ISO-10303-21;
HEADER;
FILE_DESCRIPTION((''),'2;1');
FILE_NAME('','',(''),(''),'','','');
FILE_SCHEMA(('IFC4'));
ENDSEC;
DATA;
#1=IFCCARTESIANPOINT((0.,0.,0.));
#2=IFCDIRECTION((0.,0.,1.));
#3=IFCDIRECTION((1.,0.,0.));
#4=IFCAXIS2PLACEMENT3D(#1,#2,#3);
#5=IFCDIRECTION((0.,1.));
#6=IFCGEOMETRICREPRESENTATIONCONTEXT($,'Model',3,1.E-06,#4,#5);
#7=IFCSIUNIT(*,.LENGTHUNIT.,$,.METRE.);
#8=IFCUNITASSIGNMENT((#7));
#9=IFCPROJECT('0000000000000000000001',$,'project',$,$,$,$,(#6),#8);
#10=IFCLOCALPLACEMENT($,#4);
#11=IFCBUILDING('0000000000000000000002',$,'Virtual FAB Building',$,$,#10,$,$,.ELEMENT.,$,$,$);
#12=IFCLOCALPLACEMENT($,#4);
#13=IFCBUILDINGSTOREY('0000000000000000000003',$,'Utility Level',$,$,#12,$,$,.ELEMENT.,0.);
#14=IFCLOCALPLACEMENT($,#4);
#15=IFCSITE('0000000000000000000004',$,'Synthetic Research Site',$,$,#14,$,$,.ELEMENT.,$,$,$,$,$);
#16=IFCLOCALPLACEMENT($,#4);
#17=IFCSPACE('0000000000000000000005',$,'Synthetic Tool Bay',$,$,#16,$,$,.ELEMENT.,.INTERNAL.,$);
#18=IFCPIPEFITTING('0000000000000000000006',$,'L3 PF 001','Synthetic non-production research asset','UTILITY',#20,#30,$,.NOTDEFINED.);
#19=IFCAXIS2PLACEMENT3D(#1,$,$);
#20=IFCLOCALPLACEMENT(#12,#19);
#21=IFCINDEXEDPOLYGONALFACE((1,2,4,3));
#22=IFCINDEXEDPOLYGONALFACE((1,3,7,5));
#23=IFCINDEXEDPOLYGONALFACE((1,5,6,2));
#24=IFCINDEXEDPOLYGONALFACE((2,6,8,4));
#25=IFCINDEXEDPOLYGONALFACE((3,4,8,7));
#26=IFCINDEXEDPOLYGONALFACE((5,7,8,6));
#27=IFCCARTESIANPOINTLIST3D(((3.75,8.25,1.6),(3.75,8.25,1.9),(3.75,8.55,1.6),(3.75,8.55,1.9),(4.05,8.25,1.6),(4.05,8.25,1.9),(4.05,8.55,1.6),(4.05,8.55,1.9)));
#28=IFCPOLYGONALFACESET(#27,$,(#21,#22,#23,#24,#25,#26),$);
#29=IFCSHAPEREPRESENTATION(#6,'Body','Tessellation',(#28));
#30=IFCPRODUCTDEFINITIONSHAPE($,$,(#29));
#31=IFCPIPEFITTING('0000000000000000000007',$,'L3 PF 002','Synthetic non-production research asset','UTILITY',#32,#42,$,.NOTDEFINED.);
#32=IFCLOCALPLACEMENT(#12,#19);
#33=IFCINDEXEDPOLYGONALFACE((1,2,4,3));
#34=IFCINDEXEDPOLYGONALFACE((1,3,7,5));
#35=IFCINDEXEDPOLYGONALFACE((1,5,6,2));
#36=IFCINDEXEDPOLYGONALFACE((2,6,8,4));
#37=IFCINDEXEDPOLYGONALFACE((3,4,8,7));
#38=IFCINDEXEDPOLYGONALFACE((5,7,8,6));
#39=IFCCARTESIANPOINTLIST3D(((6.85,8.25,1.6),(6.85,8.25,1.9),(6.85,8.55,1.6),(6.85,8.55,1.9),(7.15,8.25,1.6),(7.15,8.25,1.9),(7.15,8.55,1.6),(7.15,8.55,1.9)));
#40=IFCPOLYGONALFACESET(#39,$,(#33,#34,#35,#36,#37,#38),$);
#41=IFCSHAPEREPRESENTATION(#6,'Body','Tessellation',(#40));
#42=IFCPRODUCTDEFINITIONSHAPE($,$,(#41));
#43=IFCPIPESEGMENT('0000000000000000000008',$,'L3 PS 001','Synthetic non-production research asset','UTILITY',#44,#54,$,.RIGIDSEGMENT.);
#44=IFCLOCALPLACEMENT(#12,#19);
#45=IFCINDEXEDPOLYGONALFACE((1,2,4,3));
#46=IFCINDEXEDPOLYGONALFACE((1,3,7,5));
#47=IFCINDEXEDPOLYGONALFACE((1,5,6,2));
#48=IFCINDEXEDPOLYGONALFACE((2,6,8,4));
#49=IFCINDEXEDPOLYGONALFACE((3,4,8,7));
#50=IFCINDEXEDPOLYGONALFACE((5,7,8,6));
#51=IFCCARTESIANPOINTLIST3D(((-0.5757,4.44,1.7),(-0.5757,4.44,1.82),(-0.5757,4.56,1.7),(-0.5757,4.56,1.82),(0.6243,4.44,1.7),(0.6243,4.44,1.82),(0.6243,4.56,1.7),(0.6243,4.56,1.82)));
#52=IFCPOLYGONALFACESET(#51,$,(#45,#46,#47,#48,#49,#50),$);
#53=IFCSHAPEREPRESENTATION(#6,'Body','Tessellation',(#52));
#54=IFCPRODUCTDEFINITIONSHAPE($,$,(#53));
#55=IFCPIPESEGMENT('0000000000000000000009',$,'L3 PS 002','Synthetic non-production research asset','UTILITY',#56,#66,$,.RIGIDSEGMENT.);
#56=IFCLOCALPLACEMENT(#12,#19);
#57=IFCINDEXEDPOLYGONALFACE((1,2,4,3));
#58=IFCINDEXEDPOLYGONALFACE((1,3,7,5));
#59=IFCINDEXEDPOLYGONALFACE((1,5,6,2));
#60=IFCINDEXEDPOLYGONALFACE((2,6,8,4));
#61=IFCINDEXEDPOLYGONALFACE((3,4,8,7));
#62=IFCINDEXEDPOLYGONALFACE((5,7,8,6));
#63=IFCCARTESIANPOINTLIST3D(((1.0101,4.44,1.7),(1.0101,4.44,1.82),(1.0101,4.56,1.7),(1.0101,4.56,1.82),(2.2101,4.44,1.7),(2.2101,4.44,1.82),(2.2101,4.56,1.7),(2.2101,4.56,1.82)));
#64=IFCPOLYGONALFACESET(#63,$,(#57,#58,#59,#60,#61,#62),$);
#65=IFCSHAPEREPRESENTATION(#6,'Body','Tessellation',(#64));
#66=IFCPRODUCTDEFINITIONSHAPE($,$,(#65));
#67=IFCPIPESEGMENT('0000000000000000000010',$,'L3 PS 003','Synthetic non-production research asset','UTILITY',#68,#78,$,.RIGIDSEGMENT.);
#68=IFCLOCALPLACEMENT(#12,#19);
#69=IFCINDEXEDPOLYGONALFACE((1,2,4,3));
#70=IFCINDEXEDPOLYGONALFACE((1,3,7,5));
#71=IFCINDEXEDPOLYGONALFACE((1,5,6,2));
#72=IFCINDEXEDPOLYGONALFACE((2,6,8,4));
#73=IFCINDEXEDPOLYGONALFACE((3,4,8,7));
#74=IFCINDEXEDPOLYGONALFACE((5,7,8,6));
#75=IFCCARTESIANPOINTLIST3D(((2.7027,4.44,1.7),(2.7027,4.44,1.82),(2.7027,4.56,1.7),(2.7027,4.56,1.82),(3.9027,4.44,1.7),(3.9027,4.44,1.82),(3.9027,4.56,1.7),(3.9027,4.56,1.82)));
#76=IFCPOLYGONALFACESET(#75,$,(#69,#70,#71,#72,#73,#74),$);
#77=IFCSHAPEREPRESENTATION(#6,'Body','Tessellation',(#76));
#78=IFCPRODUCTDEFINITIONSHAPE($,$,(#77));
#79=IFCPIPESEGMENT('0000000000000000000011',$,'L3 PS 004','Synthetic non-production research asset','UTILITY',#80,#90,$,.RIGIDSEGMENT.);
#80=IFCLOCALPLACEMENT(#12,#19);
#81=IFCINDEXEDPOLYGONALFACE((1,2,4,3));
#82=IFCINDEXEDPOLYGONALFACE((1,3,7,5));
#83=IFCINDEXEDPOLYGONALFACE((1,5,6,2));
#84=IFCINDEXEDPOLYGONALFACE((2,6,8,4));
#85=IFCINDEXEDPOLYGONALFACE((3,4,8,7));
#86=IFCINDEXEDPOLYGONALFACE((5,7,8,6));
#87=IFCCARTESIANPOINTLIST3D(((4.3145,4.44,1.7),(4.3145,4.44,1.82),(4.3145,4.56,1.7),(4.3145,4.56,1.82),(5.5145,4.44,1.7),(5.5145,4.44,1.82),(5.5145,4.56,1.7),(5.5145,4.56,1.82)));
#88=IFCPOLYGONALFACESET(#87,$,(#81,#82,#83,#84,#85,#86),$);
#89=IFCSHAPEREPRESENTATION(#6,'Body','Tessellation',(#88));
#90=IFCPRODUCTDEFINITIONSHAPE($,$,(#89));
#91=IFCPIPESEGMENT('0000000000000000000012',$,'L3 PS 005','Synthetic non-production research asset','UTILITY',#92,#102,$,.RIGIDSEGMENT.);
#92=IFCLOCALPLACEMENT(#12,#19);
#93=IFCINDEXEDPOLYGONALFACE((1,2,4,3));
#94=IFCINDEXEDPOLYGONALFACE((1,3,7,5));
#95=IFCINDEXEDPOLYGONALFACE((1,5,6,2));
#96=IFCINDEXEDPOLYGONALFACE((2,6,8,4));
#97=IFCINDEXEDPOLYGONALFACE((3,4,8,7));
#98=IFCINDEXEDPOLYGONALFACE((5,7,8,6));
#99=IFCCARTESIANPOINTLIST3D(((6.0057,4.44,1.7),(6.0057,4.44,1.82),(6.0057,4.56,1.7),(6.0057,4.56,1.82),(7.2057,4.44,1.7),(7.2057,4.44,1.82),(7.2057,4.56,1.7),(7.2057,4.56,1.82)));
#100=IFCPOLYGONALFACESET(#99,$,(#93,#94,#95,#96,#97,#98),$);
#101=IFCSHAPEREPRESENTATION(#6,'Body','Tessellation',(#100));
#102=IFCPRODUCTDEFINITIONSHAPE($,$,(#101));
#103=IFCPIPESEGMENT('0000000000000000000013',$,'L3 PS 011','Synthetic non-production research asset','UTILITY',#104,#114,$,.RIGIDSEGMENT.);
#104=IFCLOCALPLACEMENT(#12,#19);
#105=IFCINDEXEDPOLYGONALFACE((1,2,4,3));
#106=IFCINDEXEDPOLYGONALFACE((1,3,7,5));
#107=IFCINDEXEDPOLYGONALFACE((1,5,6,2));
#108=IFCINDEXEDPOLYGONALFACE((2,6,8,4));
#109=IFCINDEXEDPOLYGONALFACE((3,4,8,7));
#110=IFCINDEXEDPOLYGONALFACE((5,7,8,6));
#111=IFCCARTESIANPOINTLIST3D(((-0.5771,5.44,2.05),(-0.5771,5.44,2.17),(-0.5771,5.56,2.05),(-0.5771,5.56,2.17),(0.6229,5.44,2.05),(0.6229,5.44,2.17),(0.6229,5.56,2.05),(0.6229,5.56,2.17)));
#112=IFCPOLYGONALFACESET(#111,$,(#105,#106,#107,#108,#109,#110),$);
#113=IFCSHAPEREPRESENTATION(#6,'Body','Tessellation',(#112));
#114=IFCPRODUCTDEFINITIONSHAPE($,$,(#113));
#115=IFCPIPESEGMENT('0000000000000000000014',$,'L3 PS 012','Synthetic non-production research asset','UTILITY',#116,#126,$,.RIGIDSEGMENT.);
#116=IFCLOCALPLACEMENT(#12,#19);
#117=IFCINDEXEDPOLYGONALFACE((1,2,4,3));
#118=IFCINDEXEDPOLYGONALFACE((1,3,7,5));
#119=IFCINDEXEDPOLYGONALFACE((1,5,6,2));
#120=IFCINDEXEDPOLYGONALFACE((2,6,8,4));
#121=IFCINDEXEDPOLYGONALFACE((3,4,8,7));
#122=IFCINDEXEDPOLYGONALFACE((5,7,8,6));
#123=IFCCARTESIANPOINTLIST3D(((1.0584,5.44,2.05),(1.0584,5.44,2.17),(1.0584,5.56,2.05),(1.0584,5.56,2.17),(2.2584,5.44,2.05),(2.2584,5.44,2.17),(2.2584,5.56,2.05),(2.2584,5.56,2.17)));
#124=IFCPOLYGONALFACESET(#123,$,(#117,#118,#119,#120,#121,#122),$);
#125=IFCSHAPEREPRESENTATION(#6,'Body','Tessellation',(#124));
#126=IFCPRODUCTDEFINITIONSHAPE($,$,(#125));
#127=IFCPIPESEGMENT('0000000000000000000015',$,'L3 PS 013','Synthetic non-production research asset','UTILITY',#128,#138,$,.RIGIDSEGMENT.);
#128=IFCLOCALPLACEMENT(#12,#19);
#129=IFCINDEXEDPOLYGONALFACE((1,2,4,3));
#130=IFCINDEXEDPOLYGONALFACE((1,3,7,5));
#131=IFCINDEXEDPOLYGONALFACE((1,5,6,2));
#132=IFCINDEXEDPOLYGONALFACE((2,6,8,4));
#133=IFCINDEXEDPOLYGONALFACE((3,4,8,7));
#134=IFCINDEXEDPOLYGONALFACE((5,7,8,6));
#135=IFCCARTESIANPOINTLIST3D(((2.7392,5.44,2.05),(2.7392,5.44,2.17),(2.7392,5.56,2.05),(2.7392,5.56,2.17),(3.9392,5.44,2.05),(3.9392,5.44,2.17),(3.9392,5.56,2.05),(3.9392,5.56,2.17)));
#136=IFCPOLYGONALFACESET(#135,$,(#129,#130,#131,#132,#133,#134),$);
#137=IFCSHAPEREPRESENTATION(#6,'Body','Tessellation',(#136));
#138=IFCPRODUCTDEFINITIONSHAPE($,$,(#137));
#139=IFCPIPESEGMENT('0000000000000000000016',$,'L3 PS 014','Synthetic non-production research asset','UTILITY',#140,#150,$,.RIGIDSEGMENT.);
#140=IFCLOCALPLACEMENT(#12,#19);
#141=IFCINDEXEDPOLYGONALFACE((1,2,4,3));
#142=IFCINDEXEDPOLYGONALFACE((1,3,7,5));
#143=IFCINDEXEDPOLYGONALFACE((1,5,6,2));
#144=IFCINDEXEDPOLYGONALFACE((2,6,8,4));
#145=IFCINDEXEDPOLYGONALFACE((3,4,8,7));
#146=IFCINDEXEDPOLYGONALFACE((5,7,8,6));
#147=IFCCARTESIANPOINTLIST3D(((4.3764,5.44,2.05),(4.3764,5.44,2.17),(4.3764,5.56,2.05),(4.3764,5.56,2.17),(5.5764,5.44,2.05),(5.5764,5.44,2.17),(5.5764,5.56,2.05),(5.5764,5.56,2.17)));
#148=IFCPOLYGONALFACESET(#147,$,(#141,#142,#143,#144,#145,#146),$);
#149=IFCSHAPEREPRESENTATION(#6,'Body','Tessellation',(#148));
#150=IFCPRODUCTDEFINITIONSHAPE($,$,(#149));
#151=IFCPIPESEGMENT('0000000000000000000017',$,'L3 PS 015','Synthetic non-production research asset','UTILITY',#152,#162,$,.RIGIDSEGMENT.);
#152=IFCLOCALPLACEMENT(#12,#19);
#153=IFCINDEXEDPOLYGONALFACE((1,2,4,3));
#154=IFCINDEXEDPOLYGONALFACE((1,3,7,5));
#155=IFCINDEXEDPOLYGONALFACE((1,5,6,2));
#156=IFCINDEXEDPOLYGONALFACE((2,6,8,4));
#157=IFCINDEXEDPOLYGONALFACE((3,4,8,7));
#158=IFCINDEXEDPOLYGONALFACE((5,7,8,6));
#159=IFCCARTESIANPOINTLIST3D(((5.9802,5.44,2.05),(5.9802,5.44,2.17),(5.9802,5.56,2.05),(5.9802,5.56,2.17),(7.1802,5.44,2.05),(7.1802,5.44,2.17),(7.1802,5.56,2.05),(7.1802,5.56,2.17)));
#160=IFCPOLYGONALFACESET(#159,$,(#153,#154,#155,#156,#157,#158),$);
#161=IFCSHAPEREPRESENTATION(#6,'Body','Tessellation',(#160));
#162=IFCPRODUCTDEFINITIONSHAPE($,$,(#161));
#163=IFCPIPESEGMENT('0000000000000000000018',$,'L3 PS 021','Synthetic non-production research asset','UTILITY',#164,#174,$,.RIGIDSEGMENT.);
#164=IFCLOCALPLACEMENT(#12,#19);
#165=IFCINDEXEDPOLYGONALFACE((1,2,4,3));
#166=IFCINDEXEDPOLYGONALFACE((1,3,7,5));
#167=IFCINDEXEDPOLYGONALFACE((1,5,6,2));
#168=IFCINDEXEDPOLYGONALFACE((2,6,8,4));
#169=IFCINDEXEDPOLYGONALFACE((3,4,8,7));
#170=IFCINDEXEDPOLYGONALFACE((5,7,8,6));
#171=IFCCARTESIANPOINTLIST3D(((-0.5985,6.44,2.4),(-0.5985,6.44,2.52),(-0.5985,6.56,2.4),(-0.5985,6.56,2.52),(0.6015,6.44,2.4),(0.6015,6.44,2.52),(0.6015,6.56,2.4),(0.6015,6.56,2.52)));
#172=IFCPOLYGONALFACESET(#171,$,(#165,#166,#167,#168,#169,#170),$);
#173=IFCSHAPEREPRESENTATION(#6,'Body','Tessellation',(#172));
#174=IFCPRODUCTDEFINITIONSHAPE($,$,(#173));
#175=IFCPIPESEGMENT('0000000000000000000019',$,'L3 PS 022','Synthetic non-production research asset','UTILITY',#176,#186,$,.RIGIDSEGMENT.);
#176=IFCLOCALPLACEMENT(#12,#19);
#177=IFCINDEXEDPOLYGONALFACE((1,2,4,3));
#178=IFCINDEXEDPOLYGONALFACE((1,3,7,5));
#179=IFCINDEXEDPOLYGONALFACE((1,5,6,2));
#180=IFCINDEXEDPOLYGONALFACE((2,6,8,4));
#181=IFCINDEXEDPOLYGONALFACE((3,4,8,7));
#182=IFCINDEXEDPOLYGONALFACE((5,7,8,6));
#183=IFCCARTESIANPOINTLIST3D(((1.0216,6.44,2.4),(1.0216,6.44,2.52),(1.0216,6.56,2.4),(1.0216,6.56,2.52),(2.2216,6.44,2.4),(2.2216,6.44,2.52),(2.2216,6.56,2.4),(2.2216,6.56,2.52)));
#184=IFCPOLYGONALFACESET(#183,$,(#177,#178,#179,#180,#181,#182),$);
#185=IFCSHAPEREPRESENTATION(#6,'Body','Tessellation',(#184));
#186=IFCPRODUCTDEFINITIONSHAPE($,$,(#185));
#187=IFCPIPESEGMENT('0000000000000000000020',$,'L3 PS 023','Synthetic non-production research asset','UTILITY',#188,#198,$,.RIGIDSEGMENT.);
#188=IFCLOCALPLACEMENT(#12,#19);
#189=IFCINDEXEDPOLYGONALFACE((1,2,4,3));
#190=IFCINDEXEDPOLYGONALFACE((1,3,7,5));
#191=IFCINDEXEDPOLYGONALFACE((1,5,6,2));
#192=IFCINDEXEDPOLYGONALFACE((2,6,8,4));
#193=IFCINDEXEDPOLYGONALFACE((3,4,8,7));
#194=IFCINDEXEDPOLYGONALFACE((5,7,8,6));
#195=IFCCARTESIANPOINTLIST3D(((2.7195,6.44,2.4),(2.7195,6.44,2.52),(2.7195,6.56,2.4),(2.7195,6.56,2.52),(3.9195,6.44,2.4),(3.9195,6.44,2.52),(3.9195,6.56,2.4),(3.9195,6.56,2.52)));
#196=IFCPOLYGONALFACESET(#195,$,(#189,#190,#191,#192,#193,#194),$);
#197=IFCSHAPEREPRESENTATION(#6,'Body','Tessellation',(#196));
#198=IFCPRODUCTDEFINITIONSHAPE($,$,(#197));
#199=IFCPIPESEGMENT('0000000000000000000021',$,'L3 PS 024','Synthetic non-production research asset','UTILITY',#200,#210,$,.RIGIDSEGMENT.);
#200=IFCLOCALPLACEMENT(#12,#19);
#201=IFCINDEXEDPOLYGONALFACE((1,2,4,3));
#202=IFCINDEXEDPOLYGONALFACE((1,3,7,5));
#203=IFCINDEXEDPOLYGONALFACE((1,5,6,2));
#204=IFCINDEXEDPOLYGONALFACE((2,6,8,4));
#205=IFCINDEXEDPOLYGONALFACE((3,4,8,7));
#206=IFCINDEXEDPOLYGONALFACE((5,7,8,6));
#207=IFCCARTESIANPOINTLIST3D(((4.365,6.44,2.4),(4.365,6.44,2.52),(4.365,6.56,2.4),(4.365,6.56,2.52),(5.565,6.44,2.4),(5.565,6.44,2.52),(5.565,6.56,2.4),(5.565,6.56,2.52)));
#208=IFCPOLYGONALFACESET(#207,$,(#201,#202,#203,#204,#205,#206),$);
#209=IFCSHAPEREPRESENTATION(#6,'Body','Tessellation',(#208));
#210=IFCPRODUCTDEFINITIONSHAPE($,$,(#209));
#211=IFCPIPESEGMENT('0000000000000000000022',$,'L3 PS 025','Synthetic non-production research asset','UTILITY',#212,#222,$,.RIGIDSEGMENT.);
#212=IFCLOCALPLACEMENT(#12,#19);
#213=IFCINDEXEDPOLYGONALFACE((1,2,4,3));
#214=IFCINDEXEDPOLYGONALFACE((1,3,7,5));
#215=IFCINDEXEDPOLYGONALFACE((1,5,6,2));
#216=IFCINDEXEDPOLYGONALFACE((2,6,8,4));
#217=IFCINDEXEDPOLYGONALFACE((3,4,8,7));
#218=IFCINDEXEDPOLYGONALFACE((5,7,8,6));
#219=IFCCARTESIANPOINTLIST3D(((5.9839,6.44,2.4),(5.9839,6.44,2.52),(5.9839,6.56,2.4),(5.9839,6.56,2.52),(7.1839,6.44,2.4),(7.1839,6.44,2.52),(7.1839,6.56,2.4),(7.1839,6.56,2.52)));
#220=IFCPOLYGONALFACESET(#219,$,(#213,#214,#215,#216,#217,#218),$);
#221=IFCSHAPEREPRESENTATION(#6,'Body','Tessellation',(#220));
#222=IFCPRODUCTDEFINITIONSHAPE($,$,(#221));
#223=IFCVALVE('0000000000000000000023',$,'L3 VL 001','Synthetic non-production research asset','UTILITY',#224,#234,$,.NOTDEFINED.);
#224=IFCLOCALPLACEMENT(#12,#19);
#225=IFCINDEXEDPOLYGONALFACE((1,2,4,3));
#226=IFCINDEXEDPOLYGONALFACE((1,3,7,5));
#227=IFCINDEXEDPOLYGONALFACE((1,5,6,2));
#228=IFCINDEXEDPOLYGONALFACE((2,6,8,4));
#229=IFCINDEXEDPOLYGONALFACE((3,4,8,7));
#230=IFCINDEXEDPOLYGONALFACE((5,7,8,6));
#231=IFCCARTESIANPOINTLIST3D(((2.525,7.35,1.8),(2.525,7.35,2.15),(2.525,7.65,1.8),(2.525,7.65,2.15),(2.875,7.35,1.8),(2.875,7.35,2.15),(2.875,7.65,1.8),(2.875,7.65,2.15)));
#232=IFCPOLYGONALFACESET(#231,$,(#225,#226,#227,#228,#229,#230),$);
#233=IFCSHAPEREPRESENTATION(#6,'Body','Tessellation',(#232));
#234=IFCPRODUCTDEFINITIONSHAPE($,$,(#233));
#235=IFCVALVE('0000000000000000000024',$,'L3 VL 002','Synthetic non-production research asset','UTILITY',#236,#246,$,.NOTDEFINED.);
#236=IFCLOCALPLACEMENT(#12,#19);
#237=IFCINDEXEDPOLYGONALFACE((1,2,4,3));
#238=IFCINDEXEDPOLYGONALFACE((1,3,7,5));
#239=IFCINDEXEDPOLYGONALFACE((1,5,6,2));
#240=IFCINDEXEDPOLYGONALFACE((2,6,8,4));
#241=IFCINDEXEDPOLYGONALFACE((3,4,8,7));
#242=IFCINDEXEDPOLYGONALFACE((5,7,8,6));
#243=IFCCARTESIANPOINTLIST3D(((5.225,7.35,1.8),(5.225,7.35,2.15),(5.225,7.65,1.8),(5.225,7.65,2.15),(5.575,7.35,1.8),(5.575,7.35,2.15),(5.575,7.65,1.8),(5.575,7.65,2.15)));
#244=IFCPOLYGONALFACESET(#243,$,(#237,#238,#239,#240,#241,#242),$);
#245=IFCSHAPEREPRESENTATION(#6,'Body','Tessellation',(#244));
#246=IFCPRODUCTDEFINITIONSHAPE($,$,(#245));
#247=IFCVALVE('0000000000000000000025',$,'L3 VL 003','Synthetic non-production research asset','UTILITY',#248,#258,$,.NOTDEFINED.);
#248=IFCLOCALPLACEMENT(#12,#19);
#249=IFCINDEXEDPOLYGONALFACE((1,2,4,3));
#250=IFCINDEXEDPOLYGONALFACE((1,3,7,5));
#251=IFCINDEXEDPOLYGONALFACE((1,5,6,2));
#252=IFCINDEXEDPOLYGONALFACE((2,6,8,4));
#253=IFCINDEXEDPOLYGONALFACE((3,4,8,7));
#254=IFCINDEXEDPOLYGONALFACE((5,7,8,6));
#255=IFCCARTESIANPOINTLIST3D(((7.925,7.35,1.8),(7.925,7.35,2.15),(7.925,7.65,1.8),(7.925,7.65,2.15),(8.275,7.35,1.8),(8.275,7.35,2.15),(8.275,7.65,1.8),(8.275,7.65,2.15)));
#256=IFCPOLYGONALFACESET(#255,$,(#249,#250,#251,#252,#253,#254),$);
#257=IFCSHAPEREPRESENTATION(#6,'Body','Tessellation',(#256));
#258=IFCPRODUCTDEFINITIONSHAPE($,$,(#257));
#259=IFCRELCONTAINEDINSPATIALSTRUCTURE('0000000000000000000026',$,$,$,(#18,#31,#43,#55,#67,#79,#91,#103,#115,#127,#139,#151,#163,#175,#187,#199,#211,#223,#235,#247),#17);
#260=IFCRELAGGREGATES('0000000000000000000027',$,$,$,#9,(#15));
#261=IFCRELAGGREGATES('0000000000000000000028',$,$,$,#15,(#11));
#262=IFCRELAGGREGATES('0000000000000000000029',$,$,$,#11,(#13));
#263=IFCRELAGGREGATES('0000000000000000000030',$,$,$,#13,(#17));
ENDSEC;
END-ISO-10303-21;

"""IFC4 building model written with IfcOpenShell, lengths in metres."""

from ifc_helpers import new_model, si_unit, direction, frame, origin_with_axes, origin_2d_with_axis, place, context, project, spatial, rectangle, extrude, element, save


model = new_model("IFC4")

# Units and contexts
model_context = context("Model", 3, precision=1e-06, world=origin_with_axes(), true_north=direction((0.0, 1.0)))
ifc_project = project(units=[si_unit("LENGTHUNIT", "METRE")], contexts=[model_context])

# Site, building, storey, space
site_placement = place(None, origin_with_axes())
site = spatial("IfcSite", under=ifc_project, at=site_placement, Name="Synthetic Research Site", CompositionType="ELEMENT")
building_placement = place(None, origin_with_axes())
building = spatial("IfcBuilding", under=site, at=building_placement, Name="Virtual FAB Building", CompositionType="ELEMENT")
storey_placement = place(None, origin_with_axes())
storey = spatial("IfcBuildingStorey", under=building, at=storey_placement, Name="Utility Level", CompositionType="ELEMENT", Elevation=0.0)
space_placement = place(None, origin_with_axes())
space = spatial("IfcSpace", under=storey, at=space_placement, Name="Synthetic Tool Bay", CompositionType="ELEMENT", PredefinedType="INTERNAL")

# Pipe fittings
for number, where, z_axis, x_axis, name in (
    (1, (3.9, 8.4, 1.6), (0.0, 0.0, 1.0), (1.0, 0.0, 0.0), "L3 PF 001"),
    (2, (7.0, 8.4, 1.6), (0.0, 0.0, 1.0), (1.0, 0.0, 0.0), "L3 PF 002"),
):
    element("IfcPipeFitting", number, at=place(None, frame(where, z_axis=z_axis, x_axis=x_axis)), inside=space, Name=name, Description="Synthetic non-production research asset", ObjectType="UTILITY", PredefinedType="NOTDEFINED", context=model_context, shape_type="SweptSolid", body=[
        extrude(rectangle(XDim=0.3, YDim=0.3, at=origin_2d_with_axis()), origin_with_axes(), (0.0, 0.0, 1.0), 0.3),
    ])

# Pipe segments
for number, where, z_axis, x_axis, name in (
    (3, (0.0243, 4.5, 1.7), (0.0, 0.0, 1.0), (1.0, 0.0, 0.0), "L3 PS 001"),
    (4, (1.6101, 4.5, 1.7), (0.0, 0.0, 1.0), (1.0, 0.0, 0.0), "L3 PS 002"),
    (5, (3.3027, 4.5, 1.7), (0.0, 0.0, 1.0), (1.0, 0.0, 0.0), "L3 PS 003"),
    (6, (4.9145, 4.5, 1.7), (0.0, 0.0, 1.0), (1.0, 0.0, 0.0), "L3 PS 004"),
    (7, (6.6057, 4.5, 1.7), (0.0, 0.0, 1.0), (1.0, 0.0, 0.0), "L3 PS 005"),
    (8, (0.0229, 5.5, 2.05), (0.0, 0.0, 1.0), (1.0, 0.0, 0.0), "L3 PS 011"),
    (9, (1.6584, 5.5, 2.05), (0.0, 0.0, 1.0), (1.0, 0.0, 0.0), "L3 PS 012"),
    (10, (3.3392, 5.5, 2.05), (0.0, 0.0, 1.0), (1.0, 0.0, 0.0), "L3 PS 013"),
    (11, (4.9764, 5.5, 2.05), (0.0, 0.0, 1.0), (1.0, 0.0, 0.0), "L3 PS 014"),
    (12, (6.5802, 5.5, 2.05), (0.0, 0.0, 1.0), (1.0, 0.0, 0.0), "L3 PS 015"),
    (13, (0.0015, 6.5, 2.4), (0.0, 0.0, 1.0), (1.0, 0.0, 0.0), "L3 PS 021"),
    (14, (1.6216, 6.5, 2.4), (0.0, 0.0, 1.0), (1.0, 0.0, 0.0), "L3 PS 022"),
    (15, (3.3195, 6.5, 2.4), (0.0, 0.0, 1.0), (1.0, 0.0, 0.0), "L3 PS 023"),
    (16, (4.965, 6.5, 2.4), (0.0, 0.0, 1.0), (1.0, 0.0, 0.0), "L3 PS 024"),
    (17, (6.5839, 6.5, 2.4), (0.0, 0.0, 1.0), (1.0, 0.0, 0.0), "L3 PS 025"),
):
    element("IfcPipeSegment", number, at=place(None, frame(where, z_axis=z_axis, x_axis=x_axis)), inside=space, Name=name, Description="Synthetic non-production research asset", ObjectType="UTILITY", PredefinedType="RIGIDSEGMENT", context=model_context, shape_type="SweptSolid", body=[
        extrude(rectangle(XDim=1.2, YDim=0.12, at=origin_2d_with_axis()), origin_with_axes(), (0.0, 0.0, 1.0), 0.12),
    ])

# Valves
for number, where, z_axis, x_axis, name in (
    (18, (2.7, 7.5, 1.8), (0.0, 0.0, 1.0), (1.0, 0.0, 0.0), "L3 VL 001"),
    (19, (5.4, 7.5, 1.8), (0.0, 0.0, 1.0), (1.0, 0.0, 0.0), "L3 VL 002"),
    (20, (8.1, 7.5, 1.8), (0.0, 0.0, 1.0), (1.0, 0.0, 0.0), "L3 VL 003"),
):
    element("IfcValve", number, at=place(None, frame(where, z_axis=z_axis, x_axis=x_axis)), inside=space, Name=name, Description="Synthetic non-production research asset", ObjectType="UTILITY", PredefinedType="NOTDEFINED", context=model_context, shape_type="SweptSolid", body=[
        extrude(rectangle(XDim=0.35, YDim=0.3, at=origin_2d_with_axis()), origin_with_axes(), (0.0, 0.0, 1.0), 0.35),
    ])

save(model, "model.ifc")
